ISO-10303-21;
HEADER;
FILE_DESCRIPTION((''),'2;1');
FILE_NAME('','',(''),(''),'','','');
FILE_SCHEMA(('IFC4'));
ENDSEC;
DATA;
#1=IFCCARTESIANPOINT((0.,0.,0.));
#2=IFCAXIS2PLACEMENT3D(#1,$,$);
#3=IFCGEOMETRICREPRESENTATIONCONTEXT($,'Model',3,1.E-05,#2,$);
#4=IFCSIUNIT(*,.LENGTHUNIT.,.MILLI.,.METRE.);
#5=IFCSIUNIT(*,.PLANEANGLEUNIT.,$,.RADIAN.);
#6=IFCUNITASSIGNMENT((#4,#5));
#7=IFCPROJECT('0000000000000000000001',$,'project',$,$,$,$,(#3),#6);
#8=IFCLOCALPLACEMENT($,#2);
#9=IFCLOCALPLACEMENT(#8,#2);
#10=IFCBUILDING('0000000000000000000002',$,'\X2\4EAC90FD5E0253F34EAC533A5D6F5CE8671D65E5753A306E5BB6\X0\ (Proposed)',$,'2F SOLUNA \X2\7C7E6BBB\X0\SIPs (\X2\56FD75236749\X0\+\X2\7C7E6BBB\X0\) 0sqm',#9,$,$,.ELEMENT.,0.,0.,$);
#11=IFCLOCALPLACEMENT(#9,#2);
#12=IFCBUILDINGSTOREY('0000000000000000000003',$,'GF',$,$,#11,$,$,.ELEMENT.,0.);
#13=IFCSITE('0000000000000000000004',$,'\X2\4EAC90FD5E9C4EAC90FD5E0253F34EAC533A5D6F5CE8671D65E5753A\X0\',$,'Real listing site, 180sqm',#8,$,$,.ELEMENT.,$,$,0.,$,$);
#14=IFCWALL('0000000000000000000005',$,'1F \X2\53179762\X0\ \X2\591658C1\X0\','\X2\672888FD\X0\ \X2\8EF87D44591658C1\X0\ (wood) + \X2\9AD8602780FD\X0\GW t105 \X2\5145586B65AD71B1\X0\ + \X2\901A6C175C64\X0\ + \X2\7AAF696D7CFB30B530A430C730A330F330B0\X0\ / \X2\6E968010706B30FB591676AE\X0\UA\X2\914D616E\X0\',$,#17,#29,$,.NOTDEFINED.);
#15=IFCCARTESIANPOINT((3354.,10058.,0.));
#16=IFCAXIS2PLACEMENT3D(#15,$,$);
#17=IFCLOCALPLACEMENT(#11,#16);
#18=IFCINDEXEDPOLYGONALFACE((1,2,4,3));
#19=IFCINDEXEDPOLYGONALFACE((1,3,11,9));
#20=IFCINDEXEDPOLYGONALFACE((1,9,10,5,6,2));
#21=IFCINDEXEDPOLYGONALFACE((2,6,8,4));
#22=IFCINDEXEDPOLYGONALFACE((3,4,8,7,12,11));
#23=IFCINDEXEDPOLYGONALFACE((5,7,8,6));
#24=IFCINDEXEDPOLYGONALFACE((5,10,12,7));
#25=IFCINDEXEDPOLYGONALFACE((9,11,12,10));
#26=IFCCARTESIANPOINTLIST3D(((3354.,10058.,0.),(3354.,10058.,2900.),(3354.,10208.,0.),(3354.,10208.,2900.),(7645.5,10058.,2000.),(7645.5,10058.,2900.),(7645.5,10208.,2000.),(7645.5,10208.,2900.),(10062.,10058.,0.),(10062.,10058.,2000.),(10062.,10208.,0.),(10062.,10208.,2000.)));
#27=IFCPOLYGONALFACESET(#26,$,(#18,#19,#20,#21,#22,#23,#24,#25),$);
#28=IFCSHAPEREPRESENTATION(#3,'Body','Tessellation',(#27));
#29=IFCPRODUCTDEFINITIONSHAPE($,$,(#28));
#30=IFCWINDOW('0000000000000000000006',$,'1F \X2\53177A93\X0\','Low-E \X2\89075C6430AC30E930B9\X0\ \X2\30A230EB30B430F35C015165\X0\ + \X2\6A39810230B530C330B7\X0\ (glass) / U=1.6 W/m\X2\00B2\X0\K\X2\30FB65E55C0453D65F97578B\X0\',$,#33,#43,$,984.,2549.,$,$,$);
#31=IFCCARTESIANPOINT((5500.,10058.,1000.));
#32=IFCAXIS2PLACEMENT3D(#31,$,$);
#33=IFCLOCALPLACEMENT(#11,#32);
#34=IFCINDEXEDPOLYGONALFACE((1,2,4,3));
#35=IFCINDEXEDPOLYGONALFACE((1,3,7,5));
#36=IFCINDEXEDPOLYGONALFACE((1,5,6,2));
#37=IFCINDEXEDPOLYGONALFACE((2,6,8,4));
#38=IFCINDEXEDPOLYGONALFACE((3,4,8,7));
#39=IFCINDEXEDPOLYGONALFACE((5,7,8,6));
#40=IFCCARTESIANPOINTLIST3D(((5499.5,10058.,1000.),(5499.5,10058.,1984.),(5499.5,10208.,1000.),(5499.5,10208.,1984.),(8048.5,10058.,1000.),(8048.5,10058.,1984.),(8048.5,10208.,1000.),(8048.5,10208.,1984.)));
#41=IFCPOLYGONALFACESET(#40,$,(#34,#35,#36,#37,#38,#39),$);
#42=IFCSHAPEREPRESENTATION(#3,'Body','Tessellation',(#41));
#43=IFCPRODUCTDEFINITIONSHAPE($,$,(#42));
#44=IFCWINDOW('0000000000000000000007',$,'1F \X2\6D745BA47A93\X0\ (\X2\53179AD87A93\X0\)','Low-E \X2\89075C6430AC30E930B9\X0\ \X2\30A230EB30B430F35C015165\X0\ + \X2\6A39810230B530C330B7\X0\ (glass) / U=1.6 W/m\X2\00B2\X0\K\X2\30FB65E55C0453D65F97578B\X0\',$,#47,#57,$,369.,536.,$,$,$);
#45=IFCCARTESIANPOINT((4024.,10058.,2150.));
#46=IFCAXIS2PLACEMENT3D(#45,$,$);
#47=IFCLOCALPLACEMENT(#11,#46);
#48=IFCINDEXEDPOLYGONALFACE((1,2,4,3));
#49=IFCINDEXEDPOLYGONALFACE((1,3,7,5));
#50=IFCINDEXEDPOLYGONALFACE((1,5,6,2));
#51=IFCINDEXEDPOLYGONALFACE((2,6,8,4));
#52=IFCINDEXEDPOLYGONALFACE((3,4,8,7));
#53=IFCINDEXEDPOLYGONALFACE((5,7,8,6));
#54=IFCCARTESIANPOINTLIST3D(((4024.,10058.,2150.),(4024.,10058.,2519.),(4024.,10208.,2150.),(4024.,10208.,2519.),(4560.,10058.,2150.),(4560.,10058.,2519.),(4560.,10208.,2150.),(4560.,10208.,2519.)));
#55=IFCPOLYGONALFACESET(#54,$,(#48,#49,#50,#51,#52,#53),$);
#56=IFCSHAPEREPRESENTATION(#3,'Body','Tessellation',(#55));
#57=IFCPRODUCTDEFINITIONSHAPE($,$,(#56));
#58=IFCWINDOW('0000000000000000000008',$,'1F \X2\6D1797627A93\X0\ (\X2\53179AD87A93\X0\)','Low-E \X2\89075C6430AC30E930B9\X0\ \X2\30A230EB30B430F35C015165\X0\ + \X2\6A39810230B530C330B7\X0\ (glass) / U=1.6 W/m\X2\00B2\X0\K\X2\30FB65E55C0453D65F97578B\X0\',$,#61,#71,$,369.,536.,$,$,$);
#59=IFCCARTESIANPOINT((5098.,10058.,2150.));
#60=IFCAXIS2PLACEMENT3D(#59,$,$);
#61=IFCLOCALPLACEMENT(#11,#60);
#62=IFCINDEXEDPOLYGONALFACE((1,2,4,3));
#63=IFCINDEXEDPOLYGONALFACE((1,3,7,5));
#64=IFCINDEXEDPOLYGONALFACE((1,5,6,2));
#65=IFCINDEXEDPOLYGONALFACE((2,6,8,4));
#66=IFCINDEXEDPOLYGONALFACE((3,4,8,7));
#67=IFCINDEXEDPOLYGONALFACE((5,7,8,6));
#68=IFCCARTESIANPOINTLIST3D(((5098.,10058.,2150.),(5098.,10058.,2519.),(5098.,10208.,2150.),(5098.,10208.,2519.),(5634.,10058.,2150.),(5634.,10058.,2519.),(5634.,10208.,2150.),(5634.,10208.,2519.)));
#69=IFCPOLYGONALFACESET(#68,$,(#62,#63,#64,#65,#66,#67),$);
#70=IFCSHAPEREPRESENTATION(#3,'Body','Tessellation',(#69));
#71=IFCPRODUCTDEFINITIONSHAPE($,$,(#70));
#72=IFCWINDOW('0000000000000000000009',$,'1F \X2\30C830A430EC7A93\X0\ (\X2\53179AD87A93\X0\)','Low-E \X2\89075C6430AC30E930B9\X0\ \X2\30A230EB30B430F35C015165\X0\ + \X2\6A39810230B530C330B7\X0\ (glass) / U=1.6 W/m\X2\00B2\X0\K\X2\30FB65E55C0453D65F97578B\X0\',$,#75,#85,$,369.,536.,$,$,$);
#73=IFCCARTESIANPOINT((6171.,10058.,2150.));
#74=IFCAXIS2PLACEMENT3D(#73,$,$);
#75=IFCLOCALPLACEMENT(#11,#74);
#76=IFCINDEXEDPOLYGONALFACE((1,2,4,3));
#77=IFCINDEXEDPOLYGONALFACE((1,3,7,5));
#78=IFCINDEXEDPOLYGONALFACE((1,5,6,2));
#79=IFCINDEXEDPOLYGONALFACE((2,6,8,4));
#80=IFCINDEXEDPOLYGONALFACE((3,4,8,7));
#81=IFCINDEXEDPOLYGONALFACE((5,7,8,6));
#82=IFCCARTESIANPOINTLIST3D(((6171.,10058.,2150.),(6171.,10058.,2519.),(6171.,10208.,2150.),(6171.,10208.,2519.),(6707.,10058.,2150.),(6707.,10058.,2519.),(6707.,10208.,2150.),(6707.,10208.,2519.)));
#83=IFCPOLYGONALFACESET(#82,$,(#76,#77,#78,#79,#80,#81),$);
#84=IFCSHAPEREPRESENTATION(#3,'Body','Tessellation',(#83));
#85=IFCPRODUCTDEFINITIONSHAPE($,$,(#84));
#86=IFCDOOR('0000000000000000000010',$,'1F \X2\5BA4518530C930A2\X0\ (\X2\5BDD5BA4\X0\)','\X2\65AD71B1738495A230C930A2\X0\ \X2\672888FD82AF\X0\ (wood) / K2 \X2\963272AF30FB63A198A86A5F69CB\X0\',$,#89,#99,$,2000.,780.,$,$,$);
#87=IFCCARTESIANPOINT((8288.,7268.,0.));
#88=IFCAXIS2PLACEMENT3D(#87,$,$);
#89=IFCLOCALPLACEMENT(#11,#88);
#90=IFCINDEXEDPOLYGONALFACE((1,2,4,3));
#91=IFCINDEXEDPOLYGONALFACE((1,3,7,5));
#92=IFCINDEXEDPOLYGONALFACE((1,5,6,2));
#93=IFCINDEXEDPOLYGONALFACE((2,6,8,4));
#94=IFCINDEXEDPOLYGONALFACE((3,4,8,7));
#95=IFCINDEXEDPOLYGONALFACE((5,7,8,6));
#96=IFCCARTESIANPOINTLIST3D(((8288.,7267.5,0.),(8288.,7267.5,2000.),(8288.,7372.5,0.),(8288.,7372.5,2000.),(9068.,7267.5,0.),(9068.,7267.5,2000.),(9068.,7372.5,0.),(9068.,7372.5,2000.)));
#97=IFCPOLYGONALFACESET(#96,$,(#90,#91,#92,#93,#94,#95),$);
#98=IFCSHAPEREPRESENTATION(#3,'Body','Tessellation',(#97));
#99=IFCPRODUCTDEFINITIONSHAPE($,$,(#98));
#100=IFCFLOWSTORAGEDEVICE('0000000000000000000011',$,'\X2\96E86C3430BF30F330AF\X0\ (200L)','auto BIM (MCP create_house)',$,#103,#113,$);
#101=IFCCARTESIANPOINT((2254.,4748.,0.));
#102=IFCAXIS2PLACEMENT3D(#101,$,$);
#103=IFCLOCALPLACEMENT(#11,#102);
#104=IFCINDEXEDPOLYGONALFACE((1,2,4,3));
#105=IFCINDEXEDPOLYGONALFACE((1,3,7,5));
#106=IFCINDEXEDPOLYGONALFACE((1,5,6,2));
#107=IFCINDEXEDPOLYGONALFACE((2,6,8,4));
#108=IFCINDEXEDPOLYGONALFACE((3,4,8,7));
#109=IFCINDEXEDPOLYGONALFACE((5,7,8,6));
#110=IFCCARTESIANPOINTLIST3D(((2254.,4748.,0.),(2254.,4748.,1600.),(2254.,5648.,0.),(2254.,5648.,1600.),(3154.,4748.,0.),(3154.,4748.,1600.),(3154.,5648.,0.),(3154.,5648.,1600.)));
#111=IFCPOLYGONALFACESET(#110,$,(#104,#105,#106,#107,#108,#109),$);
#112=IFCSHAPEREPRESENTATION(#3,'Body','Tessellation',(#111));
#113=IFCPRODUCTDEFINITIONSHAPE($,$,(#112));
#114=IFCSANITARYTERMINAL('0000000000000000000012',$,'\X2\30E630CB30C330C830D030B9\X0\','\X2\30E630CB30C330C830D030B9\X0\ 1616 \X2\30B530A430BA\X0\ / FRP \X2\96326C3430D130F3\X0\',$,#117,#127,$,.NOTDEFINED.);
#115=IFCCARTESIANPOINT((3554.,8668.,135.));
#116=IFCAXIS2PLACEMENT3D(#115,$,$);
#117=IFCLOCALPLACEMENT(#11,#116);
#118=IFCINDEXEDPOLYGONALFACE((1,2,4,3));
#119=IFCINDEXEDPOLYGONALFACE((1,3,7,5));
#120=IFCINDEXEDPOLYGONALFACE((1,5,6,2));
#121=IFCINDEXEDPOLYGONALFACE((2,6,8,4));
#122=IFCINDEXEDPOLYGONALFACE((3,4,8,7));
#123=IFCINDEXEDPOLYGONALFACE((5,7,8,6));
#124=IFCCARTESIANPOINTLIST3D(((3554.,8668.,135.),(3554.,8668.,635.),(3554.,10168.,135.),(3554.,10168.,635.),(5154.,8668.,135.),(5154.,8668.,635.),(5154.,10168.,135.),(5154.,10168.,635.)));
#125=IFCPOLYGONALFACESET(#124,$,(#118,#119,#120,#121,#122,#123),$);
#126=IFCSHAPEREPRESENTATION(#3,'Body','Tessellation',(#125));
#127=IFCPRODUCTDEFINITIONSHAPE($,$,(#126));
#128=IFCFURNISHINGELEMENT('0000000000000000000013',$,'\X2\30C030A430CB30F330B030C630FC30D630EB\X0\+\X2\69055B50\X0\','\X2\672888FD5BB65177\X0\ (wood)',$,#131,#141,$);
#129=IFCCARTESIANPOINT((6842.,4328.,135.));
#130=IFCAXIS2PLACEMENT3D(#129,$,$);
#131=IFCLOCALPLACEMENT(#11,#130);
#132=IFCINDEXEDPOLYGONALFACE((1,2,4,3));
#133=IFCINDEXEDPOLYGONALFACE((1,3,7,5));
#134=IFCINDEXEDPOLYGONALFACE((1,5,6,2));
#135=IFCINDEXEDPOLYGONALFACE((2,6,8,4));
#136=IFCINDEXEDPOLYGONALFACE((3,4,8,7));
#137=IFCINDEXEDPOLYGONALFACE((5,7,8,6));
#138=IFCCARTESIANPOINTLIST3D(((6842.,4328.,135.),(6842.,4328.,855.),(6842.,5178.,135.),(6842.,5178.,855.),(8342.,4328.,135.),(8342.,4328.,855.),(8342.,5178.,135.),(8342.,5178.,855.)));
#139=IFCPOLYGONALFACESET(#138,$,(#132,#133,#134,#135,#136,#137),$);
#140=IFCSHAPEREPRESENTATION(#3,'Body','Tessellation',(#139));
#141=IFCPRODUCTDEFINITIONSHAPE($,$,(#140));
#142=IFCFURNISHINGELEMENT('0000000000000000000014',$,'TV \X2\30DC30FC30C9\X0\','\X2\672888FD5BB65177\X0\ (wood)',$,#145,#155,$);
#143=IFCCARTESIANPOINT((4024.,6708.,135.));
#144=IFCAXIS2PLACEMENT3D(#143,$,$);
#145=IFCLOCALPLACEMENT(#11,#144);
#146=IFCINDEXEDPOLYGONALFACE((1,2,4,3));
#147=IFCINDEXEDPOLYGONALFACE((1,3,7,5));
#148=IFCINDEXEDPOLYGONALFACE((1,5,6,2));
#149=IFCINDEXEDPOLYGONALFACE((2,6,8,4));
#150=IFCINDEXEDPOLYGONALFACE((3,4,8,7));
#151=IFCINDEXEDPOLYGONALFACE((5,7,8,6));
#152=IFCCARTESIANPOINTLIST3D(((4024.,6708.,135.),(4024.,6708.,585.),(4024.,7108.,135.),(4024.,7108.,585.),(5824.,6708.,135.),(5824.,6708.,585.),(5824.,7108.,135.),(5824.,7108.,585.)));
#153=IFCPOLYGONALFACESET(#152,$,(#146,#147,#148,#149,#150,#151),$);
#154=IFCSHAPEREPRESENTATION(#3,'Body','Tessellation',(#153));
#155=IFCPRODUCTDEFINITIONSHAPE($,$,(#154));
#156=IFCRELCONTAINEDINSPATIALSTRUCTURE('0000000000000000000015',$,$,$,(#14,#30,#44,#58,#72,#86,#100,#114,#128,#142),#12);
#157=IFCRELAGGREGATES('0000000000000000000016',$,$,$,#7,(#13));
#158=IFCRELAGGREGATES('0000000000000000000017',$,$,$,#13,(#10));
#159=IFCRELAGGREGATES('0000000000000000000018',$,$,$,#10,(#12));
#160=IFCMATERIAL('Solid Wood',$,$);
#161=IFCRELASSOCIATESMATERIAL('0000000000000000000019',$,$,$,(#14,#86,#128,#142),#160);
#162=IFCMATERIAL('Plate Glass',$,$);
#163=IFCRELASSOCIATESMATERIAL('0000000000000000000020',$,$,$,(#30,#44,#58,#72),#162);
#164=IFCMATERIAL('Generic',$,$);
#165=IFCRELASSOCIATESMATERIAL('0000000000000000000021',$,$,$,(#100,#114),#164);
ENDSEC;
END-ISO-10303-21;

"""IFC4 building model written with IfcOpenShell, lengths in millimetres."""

from ifc_helpers import new_model, si_unit, frame, frame_2d, origin, place, context, project, spatial, rectangle, extrude, material, element, fill, save


model = new_model("IFC4")

# Units and contexts
model_context = context("Model", 3, precision=1e-05, world=origin())
ifc_project = project(units=[si_unit("LENGTHUNIT", "METRE", prefix="MILLI"), si_unit("PLANEANGLEUNIT", "RADIAN")], contexts=[model_context])

# Site, building, storey
site_placement = place(None, origin())
site = spatial("IfcSite", under=ifc_project, at=site_placement, Name="京都府京都市右京区嵯峨朝日町", ObjectType="Real listing site, 180sqm", CompositionType="ELEMENT", RefElevation=0.0)
building_placement = place(site_placement, origin())
building = spatial("IfcBuilding", under=site, at=building_placement, Name="京都市右京区嵯峨朝日町の家 (Proposed)", ObjectType="2F SOLUNA 籾殻SIPs (国産杉+籾殻) 0sqm", CompositionType="ELEMENT", ElevationOfRefHeight=0.0, ElevationOfTerrain=0.0)
storey_placement = place(building_placement, origin())
storey = spatial("IfcBuildingStorey", under=building, at=storey_placement, Name="GF", CompositionType="ELEMENT", Elevation=0.0)

# Wall, openings, windows
ifc_material_1 = material(Name="Solid Wood")
wall_1_placement = place(storey_placement, frame((3354.0, 10058.0, 0.0)))
wall_1 = element("IfcWall", 1, at=wall_1_placement, inside=storey, material=ifc_material_1, Name="1F 北面 外壁", Description="木製 軸組外壁 (wood) + 高性能GW t105 充填断熱 + 通気層 + 窯業系サイディング / 準耐火・外皮UA配慮", PredefinedType="NOTDEFINED", context=model_context, shape_type="SweptSolid", body=[
    extrude(rectangle(XDim=6708.0, YDim=150.0, at=frame_2d((3354.0, 75.0))), frame((3354.0, 10058.0, 0.0)), (0.0, 0.0, 1.0), 2900.0),
])
opening_1_placement = place(storey_placement, frame((5500.0, 10058.0, 1000.0)))
opening_1 = element("IfcOpeningElement", 2, at=opening_1_placement, cuts=wall_1, PredefinedType="NOTDEFINED", context=model_context, shape_type="SweptSolid", body=[
    extrude(rectangle(XDim=2549.0, YDim=150.0, at=frame_2d((1274.0, 75.0))), frame((5500.0, 10058.0, 1000.0)), (0.0, 0.0, 1.0), 984.0),
])
opening_2_placement = place(storey_placement, frame((4024.0, 10058.0, 2150.0)))
opening_2 = element("IfcOpeningElement", 3, at=opening_2_placement, cuts=wall_1, PredefinedType="NOTDEFINED", context=model_context, shape_type="SweptSolid", body=[
    extrude(rectangle(XDim=536.0, YDim=150.0, at=frame_2d((268.0, 75.0))), frame((4024.0, 10058.0, 2150.0)), (0.0, 0.0, 1.0), 369.0),
])
opening_3_placement = place(storey_placement, frame((5098.0, 10058.0, 2150.0)))
opening_3 = element("IfcOpeningElement", 4, at=opening_3_placement, cuts=wall_1, PredefinedType="NOTDEFINED", context=model_context, shape_type="SweptSolid", body=[
    extrude(rectangle(XDim=536.0, YDim=150.0, at=frame_2d((268.0, 75.0))), frame((5098.0, 10058.0, 2150.0)), (0.0, 0.0, 1.0), 369.0),
])
opening_4_placement = place(storey_placement, frame((6171.0, 10058.0, 2150.0)))
opening_4 = element("IfcOpeningElement", 5, at=opening_4_placement, cuts=wall_1, PredefinedType="NOTDEFINED", context=model_context, shape_type="SweptSolid", body=[
    extrude(rectangle(XDim=536.0, YDim=150.0, at=frame_2d((268.0, 75.0))), frame((6171.0, 10058.0, 2150.0)), (0.0, 0.0, 1.0), 369.0),
])
ifc_material_2 = material(Name="Plate Glass")
window_1_placement = place(storey_placement, frame((5500.0, 10058.0, 1000.0)))
window_1 = element("IfcWindow", 6, at=window_1_placement, inside=storey, material=ifc_material_2, Name="1F 北窓", Description="Low-E 複層ガラス アルゴン封入 + 樹脂サッシ (glass) / U=1.6 W/m²K・日射取得型", OverallHeight=984.0, OverallWidth=2549.0, context=model_context, shape_type="SweptSolid", body=[
    extrude(rectangle(XDim=2549.0, YDim=150.0, at=frame_2d((1274.0, 75.0))), frame((5500.0, 10058.0, 1000.0)), (0.0, 0.0, 1.0), 984.0),
])
fill(opening_1, window_1)
window_2_placement = place(storey_placement, frame((4024.0, 10058.0, 2150.0)))
window_2 = element("IfcWindow", 7, at=window_2_placement, inside=storey, material=ifc_material_2, Name="1F 浴室窓 (北高窓)", Description="Low-E 複層ガラス アルゴン封入 + 樹脂サッシ (glass) / U=1.6 W/m²K・日射取得型", OverallHeight=369.0, OverallWidth=536.0, context=model_context, shape_type="SweptSolid", body=[
    extrude(rectangle(XDim=536.0, YDim=150.0, at=frame_2d((268.0, 75.0))), frame((4024.0, 10058.0, 2150.0)), (0.0, 0.0, 1.0), 369.0),
])
fill(opening_2, window_2)
window_3_placement = place(storey_placement, frame((5098.0, 10058.0, 2150.0)))
window_3 = element("IfcWindow", 8, at=window_3_placement, inside=storey, material=ifc_material_2, Name="1F 洗面窓 (北高窓)", Description="Low-E 複層ガラス アルゴン封入 + 樹脂サッシ (glass) / U=1.6 W/m²K・日射取得型", OverallHeight=369.0, OverallWidth=536.0, context=model_context, shape_type="SweptSolid", body=[
    extrude(rectangle(XDim=536.0, YDim=150.0, at=frame_2d((268.0, 75.0))), frame((5098.0, 10058.0, 2150.0)), (0.0, 0.0, 1.0), 369.0),
])
fill(opening_3, window_3)
window_4_placement = place(storey_placement, frame((6171.0, 10058.0, 2150.0)))
window_4 = element("IfcWindow", 9, at=window_4_placement, inside=storey, material=ifc_material_2, Name="1F トイレ窓 (北高窓)", Description="Low-E 複層ガラス アルゴン封入 + 樹脂サッシ (glass) / U=1.6 W/m²K・日射取得型", OverallHeight=369.0, OverallWidth=536.0, context=model_context, shape_type="SweptSolid", body=[
    extrude(rectangle(XDim=536.0, YDim=150.0, at=frame_2d((268.0, 75.0))), frame((6171.0, 10058.0, 2150.0)), (0.0, 0.0, 1.0), 369.0),
])
fill(opening_4, window_4)

# Door
door_1_placement = place(storey_placement, frame((8288.0, 7268.0, 0.0)))
element("IfcDoor", 10, at=door_1_placement, inside=storey, material=ifc_material_1, Name="1F 室内ドア (寝室)", Description="断熱玄関ドア 木製芯 (wood) / K2 防犯・採風機構", OverallHeight=2000.0, OverallWidth=780.0, context=model_context, shape_type="SweptSolid", body=[
    extrude(rectangle(XDim=780.0, YDim=105.0, at=frame_2d((390.0, 52.0))), frame((8288.0, 7268.0, 0.0)), (0.0, 0.0, 1.0), 2000.0),
])

# Flow storage device
ifc_material_3 = material(Name="Generic")
flow_storage_device_placement = place(storey_placement, frame((2254.0, 4748.0, 0.0)))
element("IfcFlowStorageDevice", 11, at=flow_storage_device_placement, inside=storey, material=ifc_material_3, Name="雨水タンク (200L)", Description="auto BIM (MCP create_house)", context=model_context, shape_type="SweptSolid", body=[
    extrude(rectangle(XDim=900.0, YDim=900.0, at=frame_2d((450.0, 450.0))), frame((2254.0, 4748.0, 0.0)), (0.0, 0.0, 1.0), 1600.0),
])

# Sanitary terminal
sanitary_terminal_placement = place(storey_placement, frame((3554.0, 8668.0, 135.0)))
element("IfcSanitaryTerminal", 12, at=sanitary_terminal_placement, inside=storey, material=ifc_material_3, Name="ユニットバス", Description="ユニットバス 1616 サイズ / FRP 防水パン", PredefinedType="NOTDEFINED", context=model_context, shape_type="SweptSolid", body=[
    extrude(rectangle(XDim=1600.0, YDim=1500.0, at=frame_2d((800.0, 750.0))), frame((3554.0, 8668.0, 135.0)), (0.0, 0.0, 1.0), 500.0),
])

# Furnishing elements
furnishing_1_placement = place(storey_placement, frame((6842.0, 4328.0, 135.0)))
element("IfcFurnishingElement", 13, at=furnishing_1_placement, inside=storey, material=ifc_material_1, Name="ダイニングテーブル+椅子", Description="木製家具 (wood)", context=model_context, shape_type="SweptSolid", body=[
    extrude(rectangle(XDim=1500.0, YDim=850.0, at=frame_2d((750.0, 425.0))), frame((6842.0, 4328.0, 135.0)), (0.0, 0.0, 1.0), 720.0),
])
furnishing_2_placement = place(storey_placement, frame((4024.0, 6708.0, 135.0)))
element("IfcFurnishingElement", 14, at=furnishing_2_placement, inside=storey, material=ifc_material_1, Name="TV ボード", Description="木製家具 (wood)", context=model_context, shape_type="SweptSolid", body=[
    extrude(rectangle(XDim=1800.0, YDim=400.0, at=frame_2d((900.0, 200.0))), frame((4024.0, 6708.0, 135.0)), (0.0, 0.0, 1.0), 450.0),
])

save(model, "model.ifc")
